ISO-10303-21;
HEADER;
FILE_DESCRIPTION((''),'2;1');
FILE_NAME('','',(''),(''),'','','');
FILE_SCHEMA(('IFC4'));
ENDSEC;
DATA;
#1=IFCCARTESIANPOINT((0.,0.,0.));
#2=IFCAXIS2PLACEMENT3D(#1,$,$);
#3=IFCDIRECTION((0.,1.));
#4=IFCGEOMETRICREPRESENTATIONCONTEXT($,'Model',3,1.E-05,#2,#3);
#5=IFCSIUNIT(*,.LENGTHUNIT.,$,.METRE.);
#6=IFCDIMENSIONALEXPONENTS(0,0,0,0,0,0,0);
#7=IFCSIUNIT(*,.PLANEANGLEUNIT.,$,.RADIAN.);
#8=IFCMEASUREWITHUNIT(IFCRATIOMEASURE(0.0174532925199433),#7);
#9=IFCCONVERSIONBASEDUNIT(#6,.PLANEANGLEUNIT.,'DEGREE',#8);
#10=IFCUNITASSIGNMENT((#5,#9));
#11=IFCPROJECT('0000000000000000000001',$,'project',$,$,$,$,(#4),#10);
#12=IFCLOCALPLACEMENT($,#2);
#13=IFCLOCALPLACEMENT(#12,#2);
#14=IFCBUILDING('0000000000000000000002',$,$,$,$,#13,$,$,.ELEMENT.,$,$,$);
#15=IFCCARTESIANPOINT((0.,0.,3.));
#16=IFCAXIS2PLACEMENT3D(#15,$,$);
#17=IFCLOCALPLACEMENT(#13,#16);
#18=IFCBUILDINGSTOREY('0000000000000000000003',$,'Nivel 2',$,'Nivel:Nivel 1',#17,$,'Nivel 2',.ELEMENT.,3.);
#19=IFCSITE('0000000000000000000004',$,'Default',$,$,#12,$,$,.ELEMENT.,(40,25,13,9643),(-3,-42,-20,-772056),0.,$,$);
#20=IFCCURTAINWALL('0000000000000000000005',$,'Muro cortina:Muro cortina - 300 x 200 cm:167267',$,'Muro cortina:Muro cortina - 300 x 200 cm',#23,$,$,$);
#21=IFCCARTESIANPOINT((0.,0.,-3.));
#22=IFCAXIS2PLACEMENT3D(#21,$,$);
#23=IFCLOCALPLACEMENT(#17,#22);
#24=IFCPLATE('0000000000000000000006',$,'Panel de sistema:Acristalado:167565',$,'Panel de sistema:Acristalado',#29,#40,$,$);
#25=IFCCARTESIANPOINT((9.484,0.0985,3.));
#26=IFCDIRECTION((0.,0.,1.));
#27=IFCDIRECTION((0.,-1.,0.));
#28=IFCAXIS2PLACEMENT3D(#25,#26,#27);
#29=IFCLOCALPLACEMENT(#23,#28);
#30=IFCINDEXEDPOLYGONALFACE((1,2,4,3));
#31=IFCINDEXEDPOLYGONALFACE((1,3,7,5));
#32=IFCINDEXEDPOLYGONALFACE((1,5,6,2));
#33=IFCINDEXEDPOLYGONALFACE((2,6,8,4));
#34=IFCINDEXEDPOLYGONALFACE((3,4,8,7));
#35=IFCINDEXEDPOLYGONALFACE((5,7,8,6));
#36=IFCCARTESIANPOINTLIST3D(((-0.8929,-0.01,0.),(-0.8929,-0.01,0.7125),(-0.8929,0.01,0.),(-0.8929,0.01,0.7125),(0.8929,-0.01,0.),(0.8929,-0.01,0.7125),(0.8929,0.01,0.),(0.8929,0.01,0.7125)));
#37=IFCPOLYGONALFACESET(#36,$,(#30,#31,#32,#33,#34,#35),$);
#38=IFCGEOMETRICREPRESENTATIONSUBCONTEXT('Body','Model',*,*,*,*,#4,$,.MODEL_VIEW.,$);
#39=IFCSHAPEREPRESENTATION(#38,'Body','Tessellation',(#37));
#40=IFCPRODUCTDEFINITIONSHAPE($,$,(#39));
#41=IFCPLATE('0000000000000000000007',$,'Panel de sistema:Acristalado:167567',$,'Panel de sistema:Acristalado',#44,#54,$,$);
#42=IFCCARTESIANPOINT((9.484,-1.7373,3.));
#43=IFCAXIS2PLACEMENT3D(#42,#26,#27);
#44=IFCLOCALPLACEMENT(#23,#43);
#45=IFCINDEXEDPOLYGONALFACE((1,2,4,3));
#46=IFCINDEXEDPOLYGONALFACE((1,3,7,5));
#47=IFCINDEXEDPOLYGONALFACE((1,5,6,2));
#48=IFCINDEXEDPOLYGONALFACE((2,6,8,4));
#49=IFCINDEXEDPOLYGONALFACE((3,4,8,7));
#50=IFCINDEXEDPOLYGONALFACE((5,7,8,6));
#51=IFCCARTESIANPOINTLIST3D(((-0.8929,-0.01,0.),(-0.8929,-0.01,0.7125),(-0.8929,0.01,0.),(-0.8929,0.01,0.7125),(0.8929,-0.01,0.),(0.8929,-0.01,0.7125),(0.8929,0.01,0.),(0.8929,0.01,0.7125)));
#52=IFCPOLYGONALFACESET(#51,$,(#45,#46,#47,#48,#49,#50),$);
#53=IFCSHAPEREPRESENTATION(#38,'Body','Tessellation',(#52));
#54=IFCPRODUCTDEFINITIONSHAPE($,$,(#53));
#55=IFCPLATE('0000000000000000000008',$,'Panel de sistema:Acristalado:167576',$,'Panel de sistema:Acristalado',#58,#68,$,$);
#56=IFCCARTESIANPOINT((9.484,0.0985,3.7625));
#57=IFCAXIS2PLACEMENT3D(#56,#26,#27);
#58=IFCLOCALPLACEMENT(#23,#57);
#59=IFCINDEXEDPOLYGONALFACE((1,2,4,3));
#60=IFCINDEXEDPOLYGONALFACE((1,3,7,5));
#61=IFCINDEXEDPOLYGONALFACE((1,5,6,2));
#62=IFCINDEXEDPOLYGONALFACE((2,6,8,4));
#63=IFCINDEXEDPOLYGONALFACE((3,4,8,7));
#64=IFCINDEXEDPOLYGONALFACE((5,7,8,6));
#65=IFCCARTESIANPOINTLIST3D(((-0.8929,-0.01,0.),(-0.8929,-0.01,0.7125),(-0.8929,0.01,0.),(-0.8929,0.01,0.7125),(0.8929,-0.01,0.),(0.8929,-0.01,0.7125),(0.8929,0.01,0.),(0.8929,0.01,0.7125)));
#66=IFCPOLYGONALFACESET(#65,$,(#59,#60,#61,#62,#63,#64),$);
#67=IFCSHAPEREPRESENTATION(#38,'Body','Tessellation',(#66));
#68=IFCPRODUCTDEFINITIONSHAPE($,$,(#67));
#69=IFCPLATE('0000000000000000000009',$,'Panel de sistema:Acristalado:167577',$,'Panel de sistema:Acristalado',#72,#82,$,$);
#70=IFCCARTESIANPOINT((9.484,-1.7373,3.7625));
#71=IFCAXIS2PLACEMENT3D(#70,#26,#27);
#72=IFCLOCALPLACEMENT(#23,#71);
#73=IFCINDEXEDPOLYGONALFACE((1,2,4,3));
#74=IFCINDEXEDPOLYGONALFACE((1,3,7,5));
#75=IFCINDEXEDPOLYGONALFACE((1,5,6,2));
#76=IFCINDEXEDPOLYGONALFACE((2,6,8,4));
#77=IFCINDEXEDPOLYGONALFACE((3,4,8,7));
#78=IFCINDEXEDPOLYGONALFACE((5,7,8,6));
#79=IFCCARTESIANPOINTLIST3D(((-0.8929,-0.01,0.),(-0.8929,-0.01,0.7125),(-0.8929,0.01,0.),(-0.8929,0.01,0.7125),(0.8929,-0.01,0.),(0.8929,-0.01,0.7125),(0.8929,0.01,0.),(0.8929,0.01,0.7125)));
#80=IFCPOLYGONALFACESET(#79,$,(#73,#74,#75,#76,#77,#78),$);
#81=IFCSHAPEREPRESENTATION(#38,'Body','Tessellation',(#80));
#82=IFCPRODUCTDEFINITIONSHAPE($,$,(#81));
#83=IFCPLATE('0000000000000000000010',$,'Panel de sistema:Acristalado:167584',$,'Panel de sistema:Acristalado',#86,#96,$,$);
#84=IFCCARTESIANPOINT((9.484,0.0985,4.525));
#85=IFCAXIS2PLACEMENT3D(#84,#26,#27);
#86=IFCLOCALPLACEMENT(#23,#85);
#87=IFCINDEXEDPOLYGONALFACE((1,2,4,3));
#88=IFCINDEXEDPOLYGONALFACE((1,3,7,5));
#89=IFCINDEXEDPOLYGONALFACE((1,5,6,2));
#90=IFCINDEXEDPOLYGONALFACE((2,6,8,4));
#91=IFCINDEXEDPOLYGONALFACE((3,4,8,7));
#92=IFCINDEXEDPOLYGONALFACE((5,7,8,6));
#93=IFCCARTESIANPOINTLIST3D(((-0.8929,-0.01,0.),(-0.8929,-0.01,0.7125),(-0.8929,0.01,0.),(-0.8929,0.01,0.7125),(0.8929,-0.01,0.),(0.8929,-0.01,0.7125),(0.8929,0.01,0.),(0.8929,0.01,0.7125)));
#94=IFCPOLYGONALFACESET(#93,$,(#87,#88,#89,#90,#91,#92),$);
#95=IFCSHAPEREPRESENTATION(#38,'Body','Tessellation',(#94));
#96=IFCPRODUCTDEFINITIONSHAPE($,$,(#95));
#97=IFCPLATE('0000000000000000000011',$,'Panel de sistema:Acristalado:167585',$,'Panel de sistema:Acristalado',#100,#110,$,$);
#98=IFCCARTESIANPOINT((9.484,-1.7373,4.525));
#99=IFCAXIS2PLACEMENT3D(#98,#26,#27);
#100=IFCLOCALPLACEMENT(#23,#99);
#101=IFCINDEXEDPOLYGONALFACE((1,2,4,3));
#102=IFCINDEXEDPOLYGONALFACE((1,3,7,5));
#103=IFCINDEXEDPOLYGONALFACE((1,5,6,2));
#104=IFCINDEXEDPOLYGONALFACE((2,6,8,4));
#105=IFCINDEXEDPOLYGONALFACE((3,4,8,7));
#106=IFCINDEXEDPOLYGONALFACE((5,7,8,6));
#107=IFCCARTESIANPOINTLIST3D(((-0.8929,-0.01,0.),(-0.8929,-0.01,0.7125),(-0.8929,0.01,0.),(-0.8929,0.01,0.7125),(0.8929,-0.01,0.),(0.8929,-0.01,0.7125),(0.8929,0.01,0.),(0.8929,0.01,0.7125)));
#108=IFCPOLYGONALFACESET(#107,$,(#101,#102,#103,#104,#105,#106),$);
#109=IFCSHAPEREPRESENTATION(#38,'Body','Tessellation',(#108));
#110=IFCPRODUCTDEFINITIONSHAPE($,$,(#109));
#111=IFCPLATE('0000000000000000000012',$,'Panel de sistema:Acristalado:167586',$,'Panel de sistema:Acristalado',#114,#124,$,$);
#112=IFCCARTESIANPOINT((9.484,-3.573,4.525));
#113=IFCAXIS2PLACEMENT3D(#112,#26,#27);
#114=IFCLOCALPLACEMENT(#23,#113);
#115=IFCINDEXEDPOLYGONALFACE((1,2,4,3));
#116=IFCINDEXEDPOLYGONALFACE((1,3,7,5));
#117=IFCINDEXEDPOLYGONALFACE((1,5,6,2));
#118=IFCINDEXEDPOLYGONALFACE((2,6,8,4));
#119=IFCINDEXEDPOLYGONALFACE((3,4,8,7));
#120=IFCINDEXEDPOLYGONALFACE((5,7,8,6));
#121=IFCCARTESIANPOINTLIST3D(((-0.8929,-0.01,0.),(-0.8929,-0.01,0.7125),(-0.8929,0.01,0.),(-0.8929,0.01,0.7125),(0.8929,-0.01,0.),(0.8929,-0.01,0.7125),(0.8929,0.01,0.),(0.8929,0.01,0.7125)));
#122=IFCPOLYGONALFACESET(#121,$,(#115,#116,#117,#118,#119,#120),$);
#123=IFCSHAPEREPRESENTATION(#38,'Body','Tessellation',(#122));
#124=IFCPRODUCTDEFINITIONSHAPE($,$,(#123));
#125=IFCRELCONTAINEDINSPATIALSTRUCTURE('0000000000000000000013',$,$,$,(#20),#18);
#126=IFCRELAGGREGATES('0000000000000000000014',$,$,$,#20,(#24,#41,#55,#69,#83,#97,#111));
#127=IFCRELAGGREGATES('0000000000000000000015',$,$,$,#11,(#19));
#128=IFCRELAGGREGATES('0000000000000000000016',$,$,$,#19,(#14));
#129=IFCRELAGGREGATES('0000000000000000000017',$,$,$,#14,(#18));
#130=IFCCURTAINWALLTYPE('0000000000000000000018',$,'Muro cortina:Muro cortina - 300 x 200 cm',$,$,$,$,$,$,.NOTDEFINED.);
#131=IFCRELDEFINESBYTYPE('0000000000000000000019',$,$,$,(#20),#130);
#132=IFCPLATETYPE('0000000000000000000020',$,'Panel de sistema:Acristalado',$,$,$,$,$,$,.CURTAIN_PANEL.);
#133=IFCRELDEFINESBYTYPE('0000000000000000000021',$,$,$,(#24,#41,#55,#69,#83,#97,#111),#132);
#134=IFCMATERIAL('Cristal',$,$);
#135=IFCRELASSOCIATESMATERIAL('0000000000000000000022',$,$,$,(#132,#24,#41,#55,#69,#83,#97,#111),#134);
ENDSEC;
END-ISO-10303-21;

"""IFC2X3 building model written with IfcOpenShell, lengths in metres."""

from ifc_helpers import new_model, entity, si_unit, converted_unit, direction, frame, origin, origin_2d_with_axis, place, context, subcontext, project, spatial, rectangle, extrude, source, transform, mapped, material, type_object, type_shapes, element, aggregate, save


model = new_model("IFC2X3")

# Units and contexts
model_context = context("Model", 3, precision=1e-05, world=origin(), true_north=direction((0.0, 1.0)))
body_context = subcontext(model_context, "Body", "Model", "MODEL_VIEW")
ifc_project = project(units=[si_unit("LENGTHUNIT", "METRE"), converted_unit("PLANEANGLEUNIT", "DEGREE", entity("IfcRatioMeasure", 0.0174532925199433), si_unit("PLANEANGLEUNIT", "RADIAN"), dimensions=[0, 0, 0, 0, 0, 0, 0])], contexts=[model_context])

# Site, building, storey
site_placement = place(None, origin())
site = spatial("IfcSite", under=ifc_project, at=site_placement, Name="Default", CompositionType="ELEMENT", RefLatitude=(40, 25, 13, 9643), RefLongitude=(-3, -42, -20, -772056), RefElevation=0.0)
building_placement = place(site_placement, origin())
building = spatial("IfcBuilding", under=site, at=building_placement, CompositionType="ELEMENT")
storey_placement = place(building_placement, frame((0.0, 0.0, 3.0)))
storey = spatial("IfcBuildingStorey", under=building, at=storey_placement, Name="Nivel 2", ObjectType="Nivel:Nivel 1", LongName="Nivel 2", CompositionType="ELEMENT", Elevation=3.0)

# Curtain wall, plates
curtain_wall_type = type_object("IfcCurtainWallType", Name="Muro cortina:Muro cortina - 300 x 200 cm", PredefinedType="NOTDEFINED")
curtain_wall_placement = place(storey_placement, frame((0.0, 0.0, -3.0)))
curtain_wall = element("IfcCurtainWall", 1, at=curtain_wall_placement, inside=storey, type_object=curtain_wall_type, Name="Muro cortina:Muro cortina - 300 x 200 cm:167267", ObjectType="Muro cortina:Muro cortina - 300 x 200 cm")
ifc_material_1 = material(Name="Cristal")
plate_type = type_object("IfcPlateType", Name="Panel de sistema:Acristalado", PredefinedType="CURTAIN_PANEL", material=ifc_material_1)
shared_shape_1 = source(origin(), body_context, "Body", "SweptSolid", [
    extrude(rectangle(XDim=0.02, YDim=1.7857, at=origin_2d_with_axis()), frame((0.0, 0.0, 0.0), z_axis=(0.0, 0.0, 1.0), x_axis=(0.0, 1.0, 0.0)), (0.0, 0.0, 1.0), 0.7125),
])
type_shapes(plate_type, [shared_shape_1])
plate_1_placement = place(curtain_wall_placement, frame((9.484, 0.0985, 3.0), z_axis=(0.0, 0.0, 1.0), x_axis=(0.0, -1.0, 0.0)))
plate_1 = element("IfcPlate", 2, at=plate_1_placement, type_object=plate_type, material=ifc_material_1, Name="Panel de sistema:Acristalado:167565", ObjectType="Panel de sistema:Acristalado", context=body_context, shape_type="MappedRepresentation", body=[
    mapped(shared_shape_1, transform((0.0, 0.0, 0.0), scale=1.0)),
])
plate_2_placement = place(curtain_wall_placement, frame((9.484, -1.7373, 3.0), z_axis=(0.0, 0.0, 1.0), x_axis=(0.0, -1.0, 0.0)))
plate_2 = element("IfcPlate", 3, at=plate_2_placement, type_object=plate_type, material=ifc_material_1, Name="Panel de sistema:Acristalado:167567", ObjectType="Panel de sistema:Acristalado", context=body_context, shape_type="MappedRepresentation", body=[
    mapped(shared_shape_1, transform((0.0, 0.0, 0.0), scale=1.0)),
])
plate_3_placement = place(curtain_wall_placement, frame((9.484, 0.0985, 3.7625), z_axis=(0.0, 0.0, 1.0), x_axis=(0.0, -1.0, 0.0)))
plate_3 = element("IfcPlate", 4, at=plate_3_placement, type_object=plate_type, material=ifc_material_1, Name="Panel de sistema:Acristalado:167576", ObjectType="Panel de sistema:Acristalado", context=body_context, shape_type="MappedRepresentation", body=[
    mapped(shared_shape_1, transform((0.0, 0.0, 0.0), scale=1.0)),
])
plate_4_placement = place(curtain_wall_placement, frame((9.484, -1.7373, 3.7625), z_axis=(0.0, 0.0, 1.0), x_axis=(0.0, -1.0, 0.0)))
plate_4 = element("IfcPlate", 5, at=plate_4_placement, type_object=plate_type, material=ifc_material_1, Name="Panel de sistema:Acristalado:167577", ObjectType="Panel de sistema:Acristalado", context=body_context, shape_type="MappedRepresentation", body=[
    mapped(shared_shape_1, transform((0.0, 0.0, 0.0), scale=1.0)),
])
plate_5_placement = place(curtain_wall_placement, frame((9.484, 0.0985, 4.525), z_axis=(0.0, 0.0, 1.0), x_axis=(0.0, -1.0, 0.0)))
plate_5 = element("IfcPlate", 6, at=plate_5_placement, type_object=plate_type, material=ifc_material_1, Name="Panel de sistema:Acristalado:167584", ObjectType="Panel de sistema:Acristalado", context=body_context, shape_type="MappedRepresentation", body=[
    mapped(shared_shape_1, transform((0.0, 0.0, 0.0), scale=1.0)),
])
plate_6_placement = place(curtain_wall_placement, frame((9.484, -1.7373, 4.525), z_axis=(0.0, 0.0, 1.0), x_axis=(0.0, -1.0, 0.0)))
plate_6 = element("IfcPlate", 7, at=plate_6_placement, type_object=plate_type, material=ifc_material_1, Name="Panel de sistema:Acristalado:167585", ObjectType="Panel de sistema:Acristalado", context=body_context, shape_type="MappedRepresentation", body=[
    mapped(shared_shape_1, transform((0.0, 0.0, 0.0), scale=1.0)),
])
plate_7_placement = place(curtain_wall_placement, frame((9.484, -3.573, 4.525), z_axis=(0.0, 0.0, 1.0), x_axis=(0.0, -1.0, 0.0)))
plate_7 = element("IfcPlate", 8, at=plate_7_placement, type_object=plate_type, material=ifc_material_1, Name="Panel de sistema:Acristalado:167586", ObjectType="Panel de sistema:Acristalado", context=body_context, shape_type="MappedRepresentation", body=[
    mapped(shared_shape_1, transform((0.0, 0.0, 0.0), scale=1.0)),
])
aggregate(curtain_wall, [plate_1, plate_2, plate_3, plate_4, plate_5, plate_6, plate_7])

save(model, "model.ifc")
